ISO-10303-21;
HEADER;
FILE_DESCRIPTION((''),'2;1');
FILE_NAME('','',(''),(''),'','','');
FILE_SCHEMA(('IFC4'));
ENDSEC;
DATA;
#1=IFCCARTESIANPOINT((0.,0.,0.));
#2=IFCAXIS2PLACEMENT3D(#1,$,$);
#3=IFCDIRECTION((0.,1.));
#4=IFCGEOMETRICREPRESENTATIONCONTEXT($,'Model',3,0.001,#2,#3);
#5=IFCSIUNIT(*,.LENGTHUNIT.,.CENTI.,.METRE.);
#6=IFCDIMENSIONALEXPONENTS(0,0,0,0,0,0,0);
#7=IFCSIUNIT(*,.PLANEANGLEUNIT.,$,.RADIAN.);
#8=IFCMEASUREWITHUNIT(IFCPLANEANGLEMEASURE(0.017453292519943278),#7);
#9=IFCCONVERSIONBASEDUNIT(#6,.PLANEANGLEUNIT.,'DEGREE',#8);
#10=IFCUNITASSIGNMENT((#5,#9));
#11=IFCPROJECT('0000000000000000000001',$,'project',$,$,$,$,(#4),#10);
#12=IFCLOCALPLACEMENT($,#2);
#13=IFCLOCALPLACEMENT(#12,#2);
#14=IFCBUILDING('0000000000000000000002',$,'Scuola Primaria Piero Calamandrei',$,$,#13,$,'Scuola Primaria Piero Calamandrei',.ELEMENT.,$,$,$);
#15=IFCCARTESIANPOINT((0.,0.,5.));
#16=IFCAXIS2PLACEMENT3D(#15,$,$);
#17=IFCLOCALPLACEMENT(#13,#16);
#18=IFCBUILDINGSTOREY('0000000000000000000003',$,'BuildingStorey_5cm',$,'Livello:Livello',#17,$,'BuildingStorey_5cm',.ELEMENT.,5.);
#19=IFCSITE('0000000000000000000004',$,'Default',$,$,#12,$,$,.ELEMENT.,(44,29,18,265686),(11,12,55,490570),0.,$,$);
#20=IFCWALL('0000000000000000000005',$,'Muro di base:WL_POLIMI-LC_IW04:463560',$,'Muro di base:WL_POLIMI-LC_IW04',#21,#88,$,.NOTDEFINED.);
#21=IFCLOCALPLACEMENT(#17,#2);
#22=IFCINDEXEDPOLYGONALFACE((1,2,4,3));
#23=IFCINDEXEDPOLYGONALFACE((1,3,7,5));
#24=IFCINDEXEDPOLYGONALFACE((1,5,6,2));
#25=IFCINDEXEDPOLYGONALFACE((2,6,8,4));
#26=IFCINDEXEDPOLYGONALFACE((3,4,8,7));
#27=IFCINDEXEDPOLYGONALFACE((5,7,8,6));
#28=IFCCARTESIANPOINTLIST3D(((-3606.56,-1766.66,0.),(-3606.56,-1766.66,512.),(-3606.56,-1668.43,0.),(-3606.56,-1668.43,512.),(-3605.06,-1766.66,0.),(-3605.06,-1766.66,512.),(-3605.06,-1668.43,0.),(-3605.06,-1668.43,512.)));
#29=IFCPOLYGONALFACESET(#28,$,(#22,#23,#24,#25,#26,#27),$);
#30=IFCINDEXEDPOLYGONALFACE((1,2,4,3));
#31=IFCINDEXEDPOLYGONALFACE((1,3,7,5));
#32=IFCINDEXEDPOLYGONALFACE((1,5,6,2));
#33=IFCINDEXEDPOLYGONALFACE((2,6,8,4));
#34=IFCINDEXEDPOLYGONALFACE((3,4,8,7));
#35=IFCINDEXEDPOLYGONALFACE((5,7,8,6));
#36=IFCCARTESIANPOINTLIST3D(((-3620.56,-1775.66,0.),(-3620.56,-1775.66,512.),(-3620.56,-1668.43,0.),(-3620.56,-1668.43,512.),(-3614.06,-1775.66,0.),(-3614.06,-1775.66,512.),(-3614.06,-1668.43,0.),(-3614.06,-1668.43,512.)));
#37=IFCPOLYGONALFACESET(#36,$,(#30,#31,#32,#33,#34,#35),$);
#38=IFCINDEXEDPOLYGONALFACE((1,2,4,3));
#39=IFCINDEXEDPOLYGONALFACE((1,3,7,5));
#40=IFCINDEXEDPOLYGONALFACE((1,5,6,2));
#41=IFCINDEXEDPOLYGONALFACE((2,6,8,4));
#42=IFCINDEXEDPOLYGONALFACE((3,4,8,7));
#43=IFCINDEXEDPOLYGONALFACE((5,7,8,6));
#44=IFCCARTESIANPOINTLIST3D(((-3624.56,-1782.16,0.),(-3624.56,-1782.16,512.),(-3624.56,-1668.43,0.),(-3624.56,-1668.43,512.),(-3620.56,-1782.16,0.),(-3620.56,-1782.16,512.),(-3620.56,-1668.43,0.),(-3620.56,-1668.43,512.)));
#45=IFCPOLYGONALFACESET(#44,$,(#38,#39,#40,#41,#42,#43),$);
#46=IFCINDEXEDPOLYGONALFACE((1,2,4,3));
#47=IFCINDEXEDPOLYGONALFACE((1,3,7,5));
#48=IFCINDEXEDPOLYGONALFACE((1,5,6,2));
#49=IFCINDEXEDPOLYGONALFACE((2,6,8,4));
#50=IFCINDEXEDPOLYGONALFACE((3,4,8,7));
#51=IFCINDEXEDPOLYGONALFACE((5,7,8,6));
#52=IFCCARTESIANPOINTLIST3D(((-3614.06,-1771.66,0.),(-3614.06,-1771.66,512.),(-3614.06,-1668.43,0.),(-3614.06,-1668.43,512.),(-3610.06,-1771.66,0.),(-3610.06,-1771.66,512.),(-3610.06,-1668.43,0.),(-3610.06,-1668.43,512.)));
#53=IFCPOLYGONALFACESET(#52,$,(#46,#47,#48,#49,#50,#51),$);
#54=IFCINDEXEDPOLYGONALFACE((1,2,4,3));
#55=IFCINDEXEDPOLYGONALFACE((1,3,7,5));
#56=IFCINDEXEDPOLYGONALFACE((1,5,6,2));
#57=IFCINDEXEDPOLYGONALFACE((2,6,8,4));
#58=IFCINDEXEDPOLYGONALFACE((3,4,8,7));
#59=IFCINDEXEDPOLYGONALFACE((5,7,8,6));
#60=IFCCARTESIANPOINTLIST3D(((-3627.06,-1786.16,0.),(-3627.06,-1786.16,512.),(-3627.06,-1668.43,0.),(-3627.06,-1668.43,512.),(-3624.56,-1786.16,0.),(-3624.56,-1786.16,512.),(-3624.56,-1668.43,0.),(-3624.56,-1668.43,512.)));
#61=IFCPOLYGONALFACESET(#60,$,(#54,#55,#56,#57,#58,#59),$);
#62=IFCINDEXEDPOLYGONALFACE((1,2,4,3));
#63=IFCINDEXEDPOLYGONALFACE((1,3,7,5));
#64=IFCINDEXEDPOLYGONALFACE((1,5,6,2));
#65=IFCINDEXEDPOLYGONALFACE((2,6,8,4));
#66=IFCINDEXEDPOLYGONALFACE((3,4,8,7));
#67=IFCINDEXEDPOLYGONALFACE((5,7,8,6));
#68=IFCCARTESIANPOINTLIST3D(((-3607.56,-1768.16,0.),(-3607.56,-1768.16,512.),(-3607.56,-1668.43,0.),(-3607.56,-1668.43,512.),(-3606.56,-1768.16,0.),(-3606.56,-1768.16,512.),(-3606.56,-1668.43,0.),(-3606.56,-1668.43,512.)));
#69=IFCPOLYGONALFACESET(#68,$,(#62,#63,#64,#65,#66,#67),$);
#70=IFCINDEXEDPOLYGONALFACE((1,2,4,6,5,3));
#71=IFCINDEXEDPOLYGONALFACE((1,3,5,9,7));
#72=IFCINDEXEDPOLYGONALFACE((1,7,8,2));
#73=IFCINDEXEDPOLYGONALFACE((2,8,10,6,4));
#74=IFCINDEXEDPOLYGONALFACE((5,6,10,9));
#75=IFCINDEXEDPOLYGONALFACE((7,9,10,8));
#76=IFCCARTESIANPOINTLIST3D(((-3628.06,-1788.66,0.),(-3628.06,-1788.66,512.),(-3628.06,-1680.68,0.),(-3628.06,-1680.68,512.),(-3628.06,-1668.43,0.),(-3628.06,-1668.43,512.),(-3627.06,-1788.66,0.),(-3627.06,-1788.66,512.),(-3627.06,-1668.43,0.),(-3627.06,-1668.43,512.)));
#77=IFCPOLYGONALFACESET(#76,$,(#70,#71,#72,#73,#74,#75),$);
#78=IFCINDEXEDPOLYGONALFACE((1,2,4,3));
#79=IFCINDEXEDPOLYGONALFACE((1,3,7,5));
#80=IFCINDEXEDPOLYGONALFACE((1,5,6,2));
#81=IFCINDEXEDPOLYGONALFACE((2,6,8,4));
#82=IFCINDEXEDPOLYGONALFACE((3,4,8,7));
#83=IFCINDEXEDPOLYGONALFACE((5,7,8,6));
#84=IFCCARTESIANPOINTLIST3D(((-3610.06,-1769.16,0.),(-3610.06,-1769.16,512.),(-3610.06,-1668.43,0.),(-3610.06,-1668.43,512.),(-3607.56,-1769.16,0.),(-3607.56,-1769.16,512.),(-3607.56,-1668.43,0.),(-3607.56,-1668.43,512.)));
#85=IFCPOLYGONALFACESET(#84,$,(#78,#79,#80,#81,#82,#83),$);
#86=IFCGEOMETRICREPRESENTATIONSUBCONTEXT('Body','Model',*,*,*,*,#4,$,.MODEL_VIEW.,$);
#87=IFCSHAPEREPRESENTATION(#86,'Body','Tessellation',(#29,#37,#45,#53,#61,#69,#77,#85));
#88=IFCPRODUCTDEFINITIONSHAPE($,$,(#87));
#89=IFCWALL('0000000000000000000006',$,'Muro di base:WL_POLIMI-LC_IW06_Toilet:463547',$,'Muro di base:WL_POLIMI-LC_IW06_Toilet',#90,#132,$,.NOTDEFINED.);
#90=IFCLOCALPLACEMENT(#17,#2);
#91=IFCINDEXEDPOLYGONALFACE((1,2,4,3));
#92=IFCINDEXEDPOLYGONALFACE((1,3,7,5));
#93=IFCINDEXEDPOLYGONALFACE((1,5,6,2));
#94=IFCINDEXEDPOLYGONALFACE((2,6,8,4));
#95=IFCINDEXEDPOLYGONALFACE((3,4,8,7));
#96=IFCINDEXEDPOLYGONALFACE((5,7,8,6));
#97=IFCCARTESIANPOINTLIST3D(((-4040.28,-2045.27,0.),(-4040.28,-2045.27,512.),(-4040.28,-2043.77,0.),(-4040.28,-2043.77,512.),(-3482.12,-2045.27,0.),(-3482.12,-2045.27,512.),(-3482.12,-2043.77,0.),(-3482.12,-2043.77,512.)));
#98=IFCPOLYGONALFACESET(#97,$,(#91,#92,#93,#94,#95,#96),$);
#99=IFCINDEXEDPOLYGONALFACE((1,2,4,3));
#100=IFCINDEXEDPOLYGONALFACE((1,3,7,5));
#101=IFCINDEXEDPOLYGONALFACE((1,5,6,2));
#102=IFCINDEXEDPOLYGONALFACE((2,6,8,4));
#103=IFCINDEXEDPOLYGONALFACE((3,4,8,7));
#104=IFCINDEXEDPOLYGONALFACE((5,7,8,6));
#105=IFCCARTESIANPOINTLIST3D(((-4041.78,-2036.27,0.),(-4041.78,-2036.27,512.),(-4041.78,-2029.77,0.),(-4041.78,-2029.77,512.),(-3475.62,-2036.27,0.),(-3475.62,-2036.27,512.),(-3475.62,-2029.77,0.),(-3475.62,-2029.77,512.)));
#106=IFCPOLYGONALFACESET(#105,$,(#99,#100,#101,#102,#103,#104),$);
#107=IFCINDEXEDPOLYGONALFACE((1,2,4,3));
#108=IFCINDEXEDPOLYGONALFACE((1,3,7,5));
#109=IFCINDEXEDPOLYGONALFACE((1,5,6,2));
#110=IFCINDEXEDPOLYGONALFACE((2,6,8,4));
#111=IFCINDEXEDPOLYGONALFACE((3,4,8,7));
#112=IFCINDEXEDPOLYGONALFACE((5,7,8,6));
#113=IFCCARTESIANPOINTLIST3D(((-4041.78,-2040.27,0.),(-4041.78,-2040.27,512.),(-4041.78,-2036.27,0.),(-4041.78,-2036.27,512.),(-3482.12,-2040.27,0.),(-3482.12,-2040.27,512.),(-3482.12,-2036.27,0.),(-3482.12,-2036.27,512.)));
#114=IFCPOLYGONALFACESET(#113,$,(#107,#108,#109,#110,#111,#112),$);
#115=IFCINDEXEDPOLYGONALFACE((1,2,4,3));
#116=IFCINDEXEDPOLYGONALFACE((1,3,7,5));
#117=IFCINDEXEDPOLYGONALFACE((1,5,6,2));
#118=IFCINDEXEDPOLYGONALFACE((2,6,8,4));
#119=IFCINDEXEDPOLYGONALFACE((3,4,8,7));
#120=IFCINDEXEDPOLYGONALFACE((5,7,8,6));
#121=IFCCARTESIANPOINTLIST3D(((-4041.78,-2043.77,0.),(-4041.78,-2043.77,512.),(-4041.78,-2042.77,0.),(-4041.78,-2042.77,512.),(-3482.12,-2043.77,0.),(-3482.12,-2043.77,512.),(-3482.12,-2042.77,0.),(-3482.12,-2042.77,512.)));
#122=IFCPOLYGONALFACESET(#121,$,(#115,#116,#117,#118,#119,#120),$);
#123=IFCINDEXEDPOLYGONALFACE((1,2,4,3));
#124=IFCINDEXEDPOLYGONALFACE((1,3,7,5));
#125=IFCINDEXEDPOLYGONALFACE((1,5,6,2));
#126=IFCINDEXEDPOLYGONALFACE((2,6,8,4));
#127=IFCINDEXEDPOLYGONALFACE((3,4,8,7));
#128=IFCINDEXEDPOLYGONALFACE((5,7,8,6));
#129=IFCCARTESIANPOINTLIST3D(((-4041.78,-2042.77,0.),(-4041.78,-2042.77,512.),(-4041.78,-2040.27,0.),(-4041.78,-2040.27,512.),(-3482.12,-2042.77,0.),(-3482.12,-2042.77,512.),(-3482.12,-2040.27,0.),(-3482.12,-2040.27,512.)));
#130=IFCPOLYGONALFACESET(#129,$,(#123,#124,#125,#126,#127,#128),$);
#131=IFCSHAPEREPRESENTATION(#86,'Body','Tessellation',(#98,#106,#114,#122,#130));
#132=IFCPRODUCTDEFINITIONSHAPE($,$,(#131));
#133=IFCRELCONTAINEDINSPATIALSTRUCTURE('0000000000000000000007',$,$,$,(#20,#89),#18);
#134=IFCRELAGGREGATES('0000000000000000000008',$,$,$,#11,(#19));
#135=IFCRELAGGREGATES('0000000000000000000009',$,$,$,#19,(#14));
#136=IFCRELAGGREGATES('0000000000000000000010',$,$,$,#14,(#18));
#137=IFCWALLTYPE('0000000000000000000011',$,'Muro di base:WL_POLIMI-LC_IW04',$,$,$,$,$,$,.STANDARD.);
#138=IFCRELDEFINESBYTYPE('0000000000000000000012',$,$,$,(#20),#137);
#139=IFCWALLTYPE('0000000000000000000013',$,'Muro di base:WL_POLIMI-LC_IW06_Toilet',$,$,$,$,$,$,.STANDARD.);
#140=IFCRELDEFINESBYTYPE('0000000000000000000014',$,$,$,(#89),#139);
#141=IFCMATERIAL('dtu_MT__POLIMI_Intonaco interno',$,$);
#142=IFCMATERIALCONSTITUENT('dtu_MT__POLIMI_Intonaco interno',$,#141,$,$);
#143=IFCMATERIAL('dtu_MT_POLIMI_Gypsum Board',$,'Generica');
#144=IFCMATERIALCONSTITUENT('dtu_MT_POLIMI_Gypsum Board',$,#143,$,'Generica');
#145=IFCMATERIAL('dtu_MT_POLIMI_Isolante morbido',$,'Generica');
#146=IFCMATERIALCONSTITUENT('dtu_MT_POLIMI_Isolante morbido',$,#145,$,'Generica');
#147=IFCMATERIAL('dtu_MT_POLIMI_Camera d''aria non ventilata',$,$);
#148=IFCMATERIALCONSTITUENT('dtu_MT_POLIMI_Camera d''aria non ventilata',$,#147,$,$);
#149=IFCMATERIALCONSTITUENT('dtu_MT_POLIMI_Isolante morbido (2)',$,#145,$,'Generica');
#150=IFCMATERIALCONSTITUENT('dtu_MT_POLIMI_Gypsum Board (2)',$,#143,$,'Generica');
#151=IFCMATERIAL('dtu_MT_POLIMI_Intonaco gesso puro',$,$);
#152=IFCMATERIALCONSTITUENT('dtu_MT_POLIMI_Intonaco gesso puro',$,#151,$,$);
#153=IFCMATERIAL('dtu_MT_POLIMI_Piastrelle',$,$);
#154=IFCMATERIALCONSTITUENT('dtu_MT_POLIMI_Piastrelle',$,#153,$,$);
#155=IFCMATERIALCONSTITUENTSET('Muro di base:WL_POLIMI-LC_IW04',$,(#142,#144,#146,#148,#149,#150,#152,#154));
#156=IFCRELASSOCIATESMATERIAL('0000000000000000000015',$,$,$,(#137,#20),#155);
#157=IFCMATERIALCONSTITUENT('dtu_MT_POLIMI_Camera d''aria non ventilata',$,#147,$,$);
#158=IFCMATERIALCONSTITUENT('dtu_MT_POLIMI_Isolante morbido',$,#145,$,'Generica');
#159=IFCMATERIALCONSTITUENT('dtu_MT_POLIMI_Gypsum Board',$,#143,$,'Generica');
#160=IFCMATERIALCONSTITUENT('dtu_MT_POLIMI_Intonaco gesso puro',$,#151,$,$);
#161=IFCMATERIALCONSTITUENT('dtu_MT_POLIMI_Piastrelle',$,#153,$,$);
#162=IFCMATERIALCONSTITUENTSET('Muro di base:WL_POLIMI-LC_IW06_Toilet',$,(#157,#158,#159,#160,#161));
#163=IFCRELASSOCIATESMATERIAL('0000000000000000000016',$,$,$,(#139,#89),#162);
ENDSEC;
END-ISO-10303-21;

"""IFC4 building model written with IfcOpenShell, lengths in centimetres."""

from ifc_helpers import new_model, entity, si_unit, converted_unit, direction, frame, origin, place, context, subcontext, project, spatial, indexed_curve, outline, extrude, material, constituent, constituent_set, type_object, element, save


model = new_model("IFC4")

# Units and contexts
model_context = context("Model", 3, precision=0.001, world=origin(), true_north=direction((0.0, 1.0)))
body_context = subcontext(model_context, "Body", "Model", "MODEL_VIEW")
ifc_project = project(units=[si_unit("LENGTHUNIT", "METRE", prefix="CENTI"), converted_unit("PLANEANGLEUNIT", "DEGREE", entity("IfcPlaneAngleMeasure", 0.017453292519943278), si_unit("PLANEANGLEUNIT", "RADIAN"), dimensions=[0, 0, 0, 0, 0, 0, 0])], contexts=[model_context])

# Site, building, storey
site_placement = place(None, origin())
site = spatial("IfcSite", under=ifc_project, at=site_placement, Name="Default", CompositionType="ELEMENT", RefLatitude=(44, 29, 18, 265686), RefLongitude=(11, 12, 55, 490570), RefElevation=0.0)
building_placement = place(site_placement, origin())
building = spatial("IfcBuilding", under=site, at=building_placement, Name="Scuola Primaria Piero Calamandrei", LongName="Scuola Primaria Piero Calamandrei", CompositionType="ELEMENT")
storey_placement = place(building_placement, frame((0.0, 0.0, 5.0)))
storey = spatial("IfcBuildingStorey", under=building, at=storey_placement, Name="BuildingStorey_5cm", ObjectType="Livello:Livello", LongName="BuildingStorey_5cm", CompositionType="ELEMENT", Elevation=5.0)

# Shared definitions
ifc_material_1 = material(Name="dtu_MT_POLIMI_Intonaco gesso puro")

# Shared definitions
ifc_material_2 = material(Name="dtu_MT_POLIMI_Isolante morbido", Category="Generica")
ifc_material_3 = material(Name="dtu_MT_POLIMI_Gypsum Board", Category="Generica")
ifc_material_4 = material(Name="dtu_MT__POLIMI_Intonaco interno")
ifc_material_5 = material(Name="dtu_MT_POLIMI_Camera d'aria non ventilata")

# Wall
ifc_constituent_1 = constituent(ifc_material_4, Name="dtu_MT__POLIMI_Intonaco interno")
ifc_constituent_2 = constituent(ifc_material_3, Name="dtu_MT_POLIMI_Gypsum Board", Category="Generica")
ifc_constituent_3 = constituent(ifc_material_2, Name="dtu_MT_POLIMI_Isolante morbido", Category="Generica")
ifc_constituent_4 = constituent(ifc_material_5, Name="dtu_MT_POLIMI_Camera d'aria non ventilata")
ifc_constituent_5 = constituent(ifc_material_2, Name="dtu_MT_POLIMI_Isolante morbido (2)", Category="Generica")
ifc_constituent_6 = constituent(ifc_material_3, Name="dtu_MT_POLIMI_Gypsum Board (2)", Category="Generica")
ifc_constituent_7 = constituent(ifc_material_1, Name="dtu_MT_POLIMI_Intonaco gesso puro")
ifc_material_6 = material(Name="dtu_MT_POLIMI_Piastrelle")
ifc_constituent_8 = constituent(ifc_material_6, Name="dtu_MT_POLIMI_Piastrelle")
ifc_constituent_set_1 = constituent_set(constituents=[ifc_constituent_1, ifc_constituent_2, ifc_constituent_3, ifc_constituent_4, ifc_constituent_5, ifc_constituent_6, ifc_constituent_7, ifc_constituent_8], Name="Muro di base:WL_POLIMI-LC_IW04")
wall_type_1 = type_object("IfcWallType", Name="Muro di base:WL_POLIMI-LC_IW04", PredefinedType="STANDARD", material=ifc_constituent_set_1)
wall_1_placement = place(storey_placement, frame((-3616.56, -1766.66, 0.0), z_axis=(0.0, 0.0, 1.0), x_axis=(0.0, 1.0, 0.0)))
element("IfcWall", 1, at=wall_1_placement, inside=storey, type_object=wall_type_1, material=ifc_constituent_set_1, Name="Muro di base:WL_POLIMI-LC_IW04:463560", ObjectType="Muro di base:WL_POLIMI-LC_IW04", PredefinedType="NOTDEFINED", context=body_context, shape_type="SweptSolid", body=[
    extrude(outline(indexed_curve([(-0.75, -49.12), (0.75, -49.12), (0.75, 49.12), (-0.75, 49.12), (-0.75, -49.12)], self_intersect=False)), frame((49.12, -10.75, 0.0), z_axis=(0.0, 0.0, 1.0), x_axis=(0.0, 1.0, 0.0)), (0.0, 0.0, 1.0), 512.0),
    extrude(outline(indexed_curve([(-53.62, -3.25), (53.62, -3.25), (53.62, 3.25), (-53.62, 3.25), (-53.62, -3.25)], self_intersect=False)), frame((44.62, 0.75, 0.0)), (0.0, 0.0, 1.0), 512.0),
    extrude(outline(indexed_curve([(-56.87, -2.0), (56.87, -2.0), (56.87, 2.0), (-56.87, 2.0), (-56.87, -2.0)], self_intersect=False)), frame((41.37, 6.0, 0.0)), (0.0, 0.0, 1.0), 512.0),
    extrude(outline(indexed_curve([(-51.62, -2.0), (51.62, -2.0), (51.62, 2.0), (-51.62, 2.0), (-51.62, -2.0)], self_intersect=False)), frame((46.62, -4.5, 0.0)), (0.0, 0.0, 1.0), 512.0),
    extrude(outline(indexed_curve([(-58.87, -1.25), (58.87, -1.25), (58.87, 1.25), (-58.87, 1.25), (-58.87, -1.25)], self_intersect=False)), frame((39.37, 9.25, 0.0)), (0.0, 0.0, 1.0), 512.0),
    extrude(outline(indexed_curve([(-49.87, -0.5), (49.87, -0.5), (49.87, 0.5), (-49.87, 0.5), (-49.87, -0.5)], self_intersect=False)), frame((48.37, -9.5, 0.0)), (0.0, 0.0, 1.0), 512.0),
    extrude(outline(indexed_curve([(-38.29, -0.4), (69.69, -0.4), (69.69, 0.6), (-50.54, 0.6), (-50.54, -0.4), (-38.29, -0.4)], self_intersect=False)), frame((47.69, 11.1, 0.0), z_axis=(0.0, 0.0, 1.0), x_axis=(-1.0, 0.0, 0.0)), (0.0, 0.0, 1.0), 512.0),
    extrude(outline(indexed_curve([(-50.37, -1.25), (50.37, -1.25), (50.37, 1.25), (-50.37, 1.25), (-50.37, -1.25)], self_intersect=False)), frame((47.87, -7.75, 0.0)), (0.0, 0.0, 1.0), 512.0),
])

# Wall
ifc_constituent_9 = constituent(ifc_material_5, Name="dtu_MT_POLIMI_Camera d'aria non ventilata")
ifc_constituent_10 = constituent(ifc_material_2, Name="dtu_MT_POLIMI_Isolante morbido", Category="Generica")
ifc_constituent_11 = constituent(ifc_material_3, Name="dtu_MT_POLIMI_Gypsum Board", Category="Generica")
ifc_constituent_12 = constituent(ifc_material_1, Name="dtu_MT_POLIMI_Intonaco gesso puro")
ifc_constituent_13 = constituent(ifc_material_6, Name="dtu_MT_POLIMI_Piastrelle")
ifc_constituent_set_2 = constituent_set(constituents=[ifc_constituent_9, ifc_constituent_10, ifc_constituent_11, ifc_constituent_12, ifc_constituent_13], Name="Muro di base:WL_POLIMI-LC_IW06_Toilet")
wall_type_2 = type_object("IfcWallType", Name="Muro di base:WL_POLIMI-LC_IW06_Toilet", PredefinedType="STANDARD", material=ifc_constituent_set_2)
wall_2_placement = place(storey_placement, frame((-4040.28, -2037.52, 0.0)))
element("IfcWall", 2, at=wall_2_placement, inside=storey, type_object=wall_type_2, material=ifc_constituent_set_2, Name="Muro di base:WL_POLIMI-LC_IW06_Toilet:463547", ObjectType="Muro di base:WL_POLIMI-LC_IW06_Toilet", PredefinedType="NOTDEFINED", context=body_context, shape_type="SweptSolid", body=[
    extrude(outline(indexed_curve([(-0.75, -279.08), (0.75, -279.08), (0.75, 279.08), (-0.75, 279.08), (-0.75, -279.08)], self_intersect=False)), frame((279.08, -7.0, 0.0), z_axis=(0.0, 0.0, 1.0), x_axis=(0.0, 1.0, 0.0)), (0.0, 0.0, 1.0), 512.0),
    extrude(outline(indexed_curve([(-3.25, -283.08), (3.25, -283.08), (3.25, 283.08), (-3.25, 283.08), (-3.25, -283.08)], self_intersect=False)), frame((281.58, 4.5, 0.0), z_axis=(0.0, 0.0, 1.0), x_axis=(0.0, -1.0, 0.0)), (0.0, 0.0, 1.0), 512.0),
    extrude(outline(indexed_curve([(-279.83, -2.0), (279.83, -2.0), (279.83, 2.0), (-279.83, 2.0), (-279.83, -2.0)], self_intersect=False)), frame((278.33, -0.75, 0.0)), (0.0, 0.0, 1.0), 512.0),
    extrude(outline(indexed_curve([(-279.83, -0.5), (279.83, -0.5), (279.83, 0.5), (-279.83, 0.5), (-279.83, -0.5)], self_intersect=False)), frame((278.33, -5.75, 0.0)), (0.0, 0.0, 1.0), 512.0),
    extrude(outline(indexed_curve([(-279.83, -1.25), (279.83, -1.25), (279.83, 1.25), (-279.83, 1.25), (-279.83, -1.25)], self_intersect=False)), frame((278.33, -4.0, 0.0)), (0.0, 0.0, 1.0), 512.0),
])

save(model, "model.ifc")
